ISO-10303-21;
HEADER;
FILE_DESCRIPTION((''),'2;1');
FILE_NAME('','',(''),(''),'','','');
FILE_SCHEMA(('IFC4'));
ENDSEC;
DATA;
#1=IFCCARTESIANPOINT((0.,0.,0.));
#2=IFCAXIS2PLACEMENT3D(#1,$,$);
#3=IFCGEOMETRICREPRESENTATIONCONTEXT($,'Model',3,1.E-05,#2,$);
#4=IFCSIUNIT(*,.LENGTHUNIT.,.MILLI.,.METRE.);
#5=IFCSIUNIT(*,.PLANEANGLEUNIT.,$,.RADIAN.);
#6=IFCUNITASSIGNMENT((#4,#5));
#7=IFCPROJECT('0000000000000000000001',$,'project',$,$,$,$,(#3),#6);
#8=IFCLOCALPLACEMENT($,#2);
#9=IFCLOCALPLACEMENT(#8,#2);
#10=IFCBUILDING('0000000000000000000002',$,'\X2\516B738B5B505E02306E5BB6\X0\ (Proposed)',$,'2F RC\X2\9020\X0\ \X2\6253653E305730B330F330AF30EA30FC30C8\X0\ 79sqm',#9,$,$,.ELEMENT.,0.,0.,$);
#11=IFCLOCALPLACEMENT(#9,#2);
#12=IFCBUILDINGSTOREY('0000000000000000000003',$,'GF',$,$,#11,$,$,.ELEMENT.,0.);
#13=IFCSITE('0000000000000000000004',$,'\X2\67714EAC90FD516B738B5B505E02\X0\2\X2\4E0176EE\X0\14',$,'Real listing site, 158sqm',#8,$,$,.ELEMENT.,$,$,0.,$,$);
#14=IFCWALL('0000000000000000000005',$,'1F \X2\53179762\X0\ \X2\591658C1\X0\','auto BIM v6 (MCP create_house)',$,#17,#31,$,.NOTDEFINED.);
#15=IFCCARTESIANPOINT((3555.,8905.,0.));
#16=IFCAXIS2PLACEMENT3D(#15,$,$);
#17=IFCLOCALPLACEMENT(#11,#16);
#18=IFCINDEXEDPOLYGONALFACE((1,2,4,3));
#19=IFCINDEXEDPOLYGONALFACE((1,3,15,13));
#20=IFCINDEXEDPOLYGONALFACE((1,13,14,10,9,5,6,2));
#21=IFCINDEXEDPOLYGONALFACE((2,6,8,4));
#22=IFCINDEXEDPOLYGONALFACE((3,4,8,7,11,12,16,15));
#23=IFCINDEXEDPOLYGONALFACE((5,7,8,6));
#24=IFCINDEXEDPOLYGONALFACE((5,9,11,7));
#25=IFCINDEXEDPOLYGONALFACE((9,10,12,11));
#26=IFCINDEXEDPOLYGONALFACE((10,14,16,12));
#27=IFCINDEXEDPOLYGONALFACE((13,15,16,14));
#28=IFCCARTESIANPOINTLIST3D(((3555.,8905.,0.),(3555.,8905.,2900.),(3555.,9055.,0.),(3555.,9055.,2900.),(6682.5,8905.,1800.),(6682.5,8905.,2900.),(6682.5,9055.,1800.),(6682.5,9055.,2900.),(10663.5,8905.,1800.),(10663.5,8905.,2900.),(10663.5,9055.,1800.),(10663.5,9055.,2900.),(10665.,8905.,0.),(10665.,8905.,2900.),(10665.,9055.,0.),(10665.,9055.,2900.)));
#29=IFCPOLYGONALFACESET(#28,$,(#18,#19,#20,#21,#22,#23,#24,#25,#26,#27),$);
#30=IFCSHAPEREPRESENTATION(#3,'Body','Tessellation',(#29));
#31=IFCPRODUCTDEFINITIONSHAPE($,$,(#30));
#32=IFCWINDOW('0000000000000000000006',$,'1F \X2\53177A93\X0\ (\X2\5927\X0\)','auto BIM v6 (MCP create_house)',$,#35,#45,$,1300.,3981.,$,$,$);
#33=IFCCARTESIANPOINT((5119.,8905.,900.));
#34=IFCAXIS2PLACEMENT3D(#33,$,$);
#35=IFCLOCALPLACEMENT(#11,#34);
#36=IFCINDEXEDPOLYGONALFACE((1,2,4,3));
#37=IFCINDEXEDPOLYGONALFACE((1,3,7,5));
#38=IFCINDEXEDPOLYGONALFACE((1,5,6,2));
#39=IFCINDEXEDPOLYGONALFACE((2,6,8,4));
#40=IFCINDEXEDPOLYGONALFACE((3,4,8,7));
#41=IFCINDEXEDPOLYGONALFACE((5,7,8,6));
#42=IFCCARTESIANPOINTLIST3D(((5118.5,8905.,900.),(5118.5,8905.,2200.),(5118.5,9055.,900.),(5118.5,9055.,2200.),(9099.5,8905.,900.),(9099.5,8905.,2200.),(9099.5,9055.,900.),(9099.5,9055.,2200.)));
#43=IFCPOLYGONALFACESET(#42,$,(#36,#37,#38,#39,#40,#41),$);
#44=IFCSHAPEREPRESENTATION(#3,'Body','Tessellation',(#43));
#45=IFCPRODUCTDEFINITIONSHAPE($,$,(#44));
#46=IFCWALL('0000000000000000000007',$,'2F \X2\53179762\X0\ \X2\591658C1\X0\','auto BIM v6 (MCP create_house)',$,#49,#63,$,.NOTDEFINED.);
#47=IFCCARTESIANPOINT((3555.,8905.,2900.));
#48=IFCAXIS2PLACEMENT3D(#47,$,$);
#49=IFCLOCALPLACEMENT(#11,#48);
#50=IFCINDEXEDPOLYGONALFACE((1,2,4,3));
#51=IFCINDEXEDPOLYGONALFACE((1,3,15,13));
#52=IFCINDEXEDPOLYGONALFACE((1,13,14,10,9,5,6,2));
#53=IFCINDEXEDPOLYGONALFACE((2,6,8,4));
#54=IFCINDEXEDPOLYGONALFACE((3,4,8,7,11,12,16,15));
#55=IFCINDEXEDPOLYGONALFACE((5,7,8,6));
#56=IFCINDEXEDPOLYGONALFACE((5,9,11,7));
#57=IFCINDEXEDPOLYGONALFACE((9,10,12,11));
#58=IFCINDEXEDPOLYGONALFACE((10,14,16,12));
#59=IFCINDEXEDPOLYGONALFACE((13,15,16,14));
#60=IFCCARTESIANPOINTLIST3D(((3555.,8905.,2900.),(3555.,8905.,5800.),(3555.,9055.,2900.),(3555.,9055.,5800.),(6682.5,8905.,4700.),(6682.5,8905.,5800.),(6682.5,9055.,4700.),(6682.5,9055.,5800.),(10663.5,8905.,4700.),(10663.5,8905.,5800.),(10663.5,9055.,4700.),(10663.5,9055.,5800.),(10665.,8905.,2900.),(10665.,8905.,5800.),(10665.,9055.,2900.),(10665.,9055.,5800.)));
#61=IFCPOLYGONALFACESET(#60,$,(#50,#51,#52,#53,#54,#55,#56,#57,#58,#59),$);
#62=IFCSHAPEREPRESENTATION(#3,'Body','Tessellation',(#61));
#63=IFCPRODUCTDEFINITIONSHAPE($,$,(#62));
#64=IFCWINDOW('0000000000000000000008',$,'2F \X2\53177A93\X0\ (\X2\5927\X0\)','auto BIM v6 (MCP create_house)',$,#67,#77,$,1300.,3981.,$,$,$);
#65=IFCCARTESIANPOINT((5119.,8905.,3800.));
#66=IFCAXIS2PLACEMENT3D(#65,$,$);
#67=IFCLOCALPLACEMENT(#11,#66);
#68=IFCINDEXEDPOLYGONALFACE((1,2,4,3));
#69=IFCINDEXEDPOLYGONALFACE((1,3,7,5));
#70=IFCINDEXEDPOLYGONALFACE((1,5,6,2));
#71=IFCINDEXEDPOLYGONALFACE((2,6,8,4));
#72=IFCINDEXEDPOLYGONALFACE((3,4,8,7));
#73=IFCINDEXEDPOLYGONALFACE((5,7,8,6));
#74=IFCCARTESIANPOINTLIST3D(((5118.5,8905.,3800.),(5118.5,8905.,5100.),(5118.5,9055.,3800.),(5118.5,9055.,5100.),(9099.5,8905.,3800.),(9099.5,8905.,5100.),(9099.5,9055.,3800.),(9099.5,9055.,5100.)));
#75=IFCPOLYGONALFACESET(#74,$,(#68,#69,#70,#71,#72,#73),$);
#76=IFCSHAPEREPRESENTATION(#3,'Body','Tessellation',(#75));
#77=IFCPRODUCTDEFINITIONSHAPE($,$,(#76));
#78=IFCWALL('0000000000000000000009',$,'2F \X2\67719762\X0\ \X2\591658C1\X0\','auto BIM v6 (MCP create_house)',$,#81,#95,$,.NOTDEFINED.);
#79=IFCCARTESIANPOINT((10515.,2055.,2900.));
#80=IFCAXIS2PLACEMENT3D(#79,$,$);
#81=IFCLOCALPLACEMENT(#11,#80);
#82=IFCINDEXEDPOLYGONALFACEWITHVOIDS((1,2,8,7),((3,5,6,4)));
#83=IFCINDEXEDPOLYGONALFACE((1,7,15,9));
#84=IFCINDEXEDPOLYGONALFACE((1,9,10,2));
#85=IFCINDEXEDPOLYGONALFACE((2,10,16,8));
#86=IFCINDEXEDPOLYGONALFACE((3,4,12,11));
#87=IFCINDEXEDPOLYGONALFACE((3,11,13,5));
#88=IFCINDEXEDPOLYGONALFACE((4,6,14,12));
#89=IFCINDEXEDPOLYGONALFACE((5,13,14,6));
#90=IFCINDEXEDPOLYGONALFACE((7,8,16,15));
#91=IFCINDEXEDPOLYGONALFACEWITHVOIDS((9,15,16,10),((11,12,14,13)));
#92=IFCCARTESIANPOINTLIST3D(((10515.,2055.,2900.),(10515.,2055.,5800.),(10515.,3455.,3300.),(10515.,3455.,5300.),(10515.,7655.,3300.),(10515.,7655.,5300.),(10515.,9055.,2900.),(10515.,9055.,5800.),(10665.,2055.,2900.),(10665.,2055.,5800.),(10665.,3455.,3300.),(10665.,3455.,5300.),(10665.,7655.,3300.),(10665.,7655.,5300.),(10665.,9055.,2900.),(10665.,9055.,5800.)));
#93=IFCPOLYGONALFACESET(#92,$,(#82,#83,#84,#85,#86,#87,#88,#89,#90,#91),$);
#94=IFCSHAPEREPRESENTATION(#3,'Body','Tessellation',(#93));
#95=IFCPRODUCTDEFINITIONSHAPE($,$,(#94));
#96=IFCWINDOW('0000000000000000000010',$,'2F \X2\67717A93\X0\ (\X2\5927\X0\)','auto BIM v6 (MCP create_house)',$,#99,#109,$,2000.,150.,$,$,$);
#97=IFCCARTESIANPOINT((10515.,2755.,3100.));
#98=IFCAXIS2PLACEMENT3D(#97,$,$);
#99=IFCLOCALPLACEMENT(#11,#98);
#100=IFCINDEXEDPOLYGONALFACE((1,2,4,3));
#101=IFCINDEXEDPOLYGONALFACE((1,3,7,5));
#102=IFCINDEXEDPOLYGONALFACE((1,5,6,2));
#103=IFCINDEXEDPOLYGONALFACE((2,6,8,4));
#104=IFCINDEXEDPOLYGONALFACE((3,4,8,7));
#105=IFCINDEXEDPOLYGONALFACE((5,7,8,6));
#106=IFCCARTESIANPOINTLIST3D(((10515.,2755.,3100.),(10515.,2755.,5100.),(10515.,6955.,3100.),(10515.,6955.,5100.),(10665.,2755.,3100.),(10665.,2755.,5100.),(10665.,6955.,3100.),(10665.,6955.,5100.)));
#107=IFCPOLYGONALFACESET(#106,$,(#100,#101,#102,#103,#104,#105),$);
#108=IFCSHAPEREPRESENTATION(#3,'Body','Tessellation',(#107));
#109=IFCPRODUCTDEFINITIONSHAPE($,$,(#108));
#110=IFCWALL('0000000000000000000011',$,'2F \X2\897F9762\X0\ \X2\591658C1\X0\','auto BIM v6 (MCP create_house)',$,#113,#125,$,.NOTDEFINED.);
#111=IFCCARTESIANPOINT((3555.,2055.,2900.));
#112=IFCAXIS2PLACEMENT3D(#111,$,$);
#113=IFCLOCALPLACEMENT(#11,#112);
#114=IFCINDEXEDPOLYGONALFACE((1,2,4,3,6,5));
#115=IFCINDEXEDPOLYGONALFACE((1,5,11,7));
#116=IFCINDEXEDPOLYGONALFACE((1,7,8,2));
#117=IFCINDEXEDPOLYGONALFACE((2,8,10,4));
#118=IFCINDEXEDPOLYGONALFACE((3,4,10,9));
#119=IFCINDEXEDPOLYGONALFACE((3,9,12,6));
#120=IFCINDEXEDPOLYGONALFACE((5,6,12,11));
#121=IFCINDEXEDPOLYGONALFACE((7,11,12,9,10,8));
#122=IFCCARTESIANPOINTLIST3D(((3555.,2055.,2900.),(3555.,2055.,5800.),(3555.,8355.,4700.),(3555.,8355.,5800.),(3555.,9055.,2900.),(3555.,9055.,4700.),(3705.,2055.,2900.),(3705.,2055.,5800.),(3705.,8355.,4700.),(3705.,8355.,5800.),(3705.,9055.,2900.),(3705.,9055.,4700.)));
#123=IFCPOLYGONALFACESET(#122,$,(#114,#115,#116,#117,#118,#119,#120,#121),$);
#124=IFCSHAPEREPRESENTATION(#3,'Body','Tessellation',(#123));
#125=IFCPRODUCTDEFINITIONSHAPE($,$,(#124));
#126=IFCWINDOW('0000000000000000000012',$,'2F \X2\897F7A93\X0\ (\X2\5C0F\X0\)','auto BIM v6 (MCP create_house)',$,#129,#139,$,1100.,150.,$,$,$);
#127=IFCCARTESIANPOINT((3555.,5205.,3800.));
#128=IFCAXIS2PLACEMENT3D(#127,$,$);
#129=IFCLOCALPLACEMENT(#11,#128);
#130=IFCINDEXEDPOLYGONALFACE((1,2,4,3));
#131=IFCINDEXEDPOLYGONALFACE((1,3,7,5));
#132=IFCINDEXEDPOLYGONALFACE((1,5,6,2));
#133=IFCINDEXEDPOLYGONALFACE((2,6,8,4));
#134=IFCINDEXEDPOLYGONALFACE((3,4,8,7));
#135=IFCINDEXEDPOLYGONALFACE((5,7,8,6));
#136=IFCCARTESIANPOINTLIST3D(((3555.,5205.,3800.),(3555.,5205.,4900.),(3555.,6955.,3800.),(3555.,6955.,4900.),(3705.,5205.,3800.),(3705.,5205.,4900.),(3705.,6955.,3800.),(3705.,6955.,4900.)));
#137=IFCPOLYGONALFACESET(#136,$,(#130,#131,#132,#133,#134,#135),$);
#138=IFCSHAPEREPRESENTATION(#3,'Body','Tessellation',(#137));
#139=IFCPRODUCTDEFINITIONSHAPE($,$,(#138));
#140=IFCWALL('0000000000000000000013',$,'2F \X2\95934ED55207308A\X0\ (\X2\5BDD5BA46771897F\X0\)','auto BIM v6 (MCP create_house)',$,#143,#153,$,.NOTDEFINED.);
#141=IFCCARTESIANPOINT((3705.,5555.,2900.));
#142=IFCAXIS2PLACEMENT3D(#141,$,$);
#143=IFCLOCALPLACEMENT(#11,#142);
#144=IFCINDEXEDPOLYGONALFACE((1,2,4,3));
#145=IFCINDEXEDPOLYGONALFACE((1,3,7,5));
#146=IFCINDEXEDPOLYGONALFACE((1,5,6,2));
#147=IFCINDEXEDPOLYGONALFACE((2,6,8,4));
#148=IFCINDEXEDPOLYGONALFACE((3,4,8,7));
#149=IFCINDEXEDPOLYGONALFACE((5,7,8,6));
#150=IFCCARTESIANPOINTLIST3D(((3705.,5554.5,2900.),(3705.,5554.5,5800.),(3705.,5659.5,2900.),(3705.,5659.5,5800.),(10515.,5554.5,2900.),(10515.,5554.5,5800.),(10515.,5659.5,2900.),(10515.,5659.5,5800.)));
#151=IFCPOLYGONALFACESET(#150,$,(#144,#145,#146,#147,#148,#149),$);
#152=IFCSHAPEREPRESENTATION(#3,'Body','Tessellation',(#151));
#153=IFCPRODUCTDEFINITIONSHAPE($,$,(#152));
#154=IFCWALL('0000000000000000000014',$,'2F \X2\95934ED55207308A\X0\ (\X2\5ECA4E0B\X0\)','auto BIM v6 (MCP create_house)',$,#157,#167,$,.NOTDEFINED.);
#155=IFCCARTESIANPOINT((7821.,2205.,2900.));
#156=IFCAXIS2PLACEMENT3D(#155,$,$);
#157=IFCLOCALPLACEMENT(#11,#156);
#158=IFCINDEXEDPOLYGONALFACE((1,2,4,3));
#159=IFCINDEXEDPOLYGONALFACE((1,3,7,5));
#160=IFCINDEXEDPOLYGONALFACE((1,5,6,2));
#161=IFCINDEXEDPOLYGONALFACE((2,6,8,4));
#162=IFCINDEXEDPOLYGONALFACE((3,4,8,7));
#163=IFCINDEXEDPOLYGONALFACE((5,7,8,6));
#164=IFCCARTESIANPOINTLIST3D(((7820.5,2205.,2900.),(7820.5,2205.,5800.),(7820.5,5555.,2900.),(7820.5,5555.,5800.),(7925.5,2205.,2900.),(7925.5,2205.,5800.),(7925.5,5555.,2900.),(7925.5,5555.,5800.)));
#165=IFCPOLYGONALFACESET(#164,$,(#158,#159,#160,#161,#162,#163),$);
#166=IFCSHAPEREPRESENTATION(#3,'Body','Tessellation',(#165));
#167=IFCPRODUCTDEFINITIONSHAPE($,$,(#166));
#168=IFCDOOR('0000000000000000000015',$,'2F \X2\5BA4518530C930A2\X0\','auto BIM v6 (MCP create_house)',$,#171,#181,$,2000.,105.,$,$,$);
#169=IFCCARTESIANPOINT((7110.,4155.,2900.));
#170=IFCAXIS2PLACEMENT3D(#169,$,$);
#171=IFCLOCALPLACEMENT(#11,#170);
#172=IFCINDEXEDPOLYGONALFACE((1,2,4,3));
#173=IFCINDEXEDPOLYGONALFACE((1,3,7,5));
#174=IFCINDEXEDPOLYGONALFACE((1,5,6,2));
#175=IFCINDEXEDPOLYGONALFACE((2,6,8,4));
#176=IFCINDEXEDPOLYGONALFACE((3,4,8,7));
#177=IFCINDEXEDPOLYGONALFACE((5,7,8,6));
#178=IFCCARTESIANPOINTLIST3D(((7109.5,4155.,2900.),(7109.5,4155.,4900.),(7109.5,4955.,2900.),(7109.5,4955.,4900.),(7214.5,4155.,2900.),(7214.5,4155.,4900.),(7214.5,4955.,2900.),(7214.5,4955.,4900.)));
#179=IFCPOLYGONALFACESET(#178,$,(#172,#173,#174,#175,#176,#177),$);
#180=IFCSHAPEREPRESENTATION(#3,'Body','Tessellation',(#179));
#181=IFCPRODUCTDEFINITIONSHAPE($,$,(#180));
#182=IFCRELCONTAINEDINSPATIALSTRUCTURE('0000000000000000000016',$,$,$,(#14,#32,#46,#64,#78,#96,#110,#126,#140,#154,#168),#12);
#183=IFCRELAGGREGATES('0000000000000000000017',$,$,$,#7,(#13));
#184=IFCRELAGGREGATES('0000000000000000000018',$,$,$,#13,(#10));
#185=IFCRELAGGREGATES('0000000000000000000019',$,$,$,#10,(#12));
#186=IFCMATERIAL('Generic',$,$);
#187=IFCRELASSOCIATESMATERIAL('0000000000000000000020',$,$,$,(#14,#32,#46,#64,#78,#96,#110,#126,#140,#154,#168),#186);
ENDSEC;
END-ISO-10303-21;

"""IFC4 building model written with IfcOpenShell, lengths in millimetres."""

from ifc_helpers import new_model, si_unit, frame, frame_2d, origin, place, context, project, spatial, rectangle, extrude, material, element, fill, save


model = new_model("IFC4")

# Units and contexts
model_context = context("Model", 3, precision=1e-05, world=origin())
ifc_project = project(units=[si_unit("LENGTHUNIT", "METRE", prefix="MILLI"), si_unit("PLANEANGLEUNIT", "RADIAN")], contexts=[model_context])

# Site, building, storey
site_placement = place(None, origin())
site = spatial("IfcSite", under=ifc_project, at=site_placement, Name="東京都八王子市2丁目14", ObjectType="Real listing site, 158sqm", CompositionType="ELEMENT", RefElevation=0.0)
building_placement = place(site_placement, origin())
building = spatial("IfcBuilding", under=site, at=building_placement, Name="八王子市の家 (Proposed)", ObjectType="2F RC造 打放しコンクリート 79sqm", CompositionType="ELEMENT", ElevationOfRefHeight=0.0, ElevationOfTerrain=0.0)
storey_placement = place(building_placement, origin())
storey = spatial("IfcBuildingStorey", under=building, at=storey_placement, Name="GF", CompositionType="ELEMENT", Elevation=0.0)

# Wall, opening, window
ifc_material = material(Name="Generic")
wall_1_placement = place(storey_placement, frame((3555.0, 8905.0, 0.0)))
wall_1 = element("IfcWall", 1, at=wall_1_placement, inside=storey, material=ifc_material, Name="1F 北面 外壁", Description="auto BIM v6 (MCP create_house)", PredefinedType="NOTDEFINED", context=model_context, shape_type="SweptSolid", body=[
    extrude(rectangle(XDim=7110.0, YDim=150.0, at=frame_2d((3555.0, 75.0))), frame((3555.0, 8905.0, 0.0)), (0.0, 0.0, 1.0), 2900.0),
])
opening_1_placement = place(storey_placement, frame((5119.0, 8905.0, 900.0)))
opening_1 = element("IfcOpeningElement", 2, at=opening_1_placement, cuts=wall_1, PredefinedType="NOTDEFINED", context=model_context, shape_type="SweptSolid", body=[
    extrude(rectangle(XDim=3981.0, YDim=150.0, at=frame_2d((1990.0, 75.0))), frame((5119.0, 8905.0, 900.0)), (0.0, 0.0, 1.0), 1300.0),
])
window_1_placement = place(storey_placement, frame((5119.0, 8905.0, 900.0)))
window_1 = element("IfcWindow", 3, at=window_1_placement, inside=storey, material=ifc_material, Name="1F 北窓 (大)", Description="auto BIM v6 (MCP create_house)", OverallHeight=1300.0, OverallWidth=3981.0, context=model_context, shape_type="SweptSolid", body=[
    extrude(rectangle(XDim=3981.0, YDim=150.0, at=frame_2d((1990.0, 75.0))), frame((5119.0, 8905.0, 900.0)), (0.0, 0.0, 1.0), 1300.0),
])
fill(opening_1, window_1)

# Walls, openings, windows
wall_2_placement = place(storey_placement, frame((3555.0, 8905.0, 2900.0)))
wall_2 = element("IfcWall", 4, at=wall_2_placement, inside=storey, material=ifc_material, Name="2F 北面 外壁", Description="auto BIM v6 (MCP create_house)", PredefinedType="NOTDEFINED", context=model_context, shape_type="SweptSolid", body=[
    extrude(rectangle(XDim=7110.0, YDim=150.0, at=frame_2d((3555.0, 75.0))), frame((3555.0, 8905.0, 2900.0)), (0.0, 0.0, 1.0), 2900.0),
])
opening_2_placement = place(storey_placement, frame((5119.0, 8905.0, 3800.0)))
opening_2 = element("IfcOpeningElement", 5, at=opening_2_placement, cuts=wall_2, PredefinedType="NOTDEFINED", context=model_context, shape_type="SweptSolid", body=[
    extrude(rectangle(XDim=3981.0, YDim=150.0, at=frame_2d((1990.0, 75.0))), frame((5119.0, 8905.0, 3800.0)), (0.0, 0.0, 1.0), 1300.0),
])
window_2_placement = place(storey_placement, frame((5119.0, 8905.0, 3800.0)))
window_2 = element("IfcWindow", 6, at=window_2_placement, inside=storey, material=ifc_material, Name="2F 北窓 (大)", Description="auto BIM v6 (MCP create_house)", OverallHeight=1300.0, OverallWidth=3981.0, context=model_context, shape_type="SweptSolid", body=[
    extrude(rectangle(XDim=3981.0, YDim=150.0, at=frame_2d((1990.0, 75.0))), frame((5119.0, 8905.0, 3800.0)), (0.0, 0.0, 1.0), 1300.0),
])
fill(opening_2, window_2)
wall_3_placement = place(storey_placement, frame((10515.0, 2055.0, 2900.0)))
wall_3 = element("IfcWall", 7, at=wall_3_placement, inside=storey, material=ifc_material, Name="2F 東面 外壁", Description="auto BIM v6 (MCP create_house)", PredefinedType="NOTDEFINED", context=model_context, shape_type="SweptSolid", body=[
    extrude(rectangle(XDim=150.0, YDim=7000.0, at=frame_2d((75.0, 3500.0))), frame((10515.0, 2055.0, 2900.0)), (0.0, 0.0, 1.0), 2900.0),
])
opening_3_placement = place(storey_placement, frame((10515.0, 2755.0, 3100.0)))
opening_3 = element("IfcOpeningElement", 8, at=opening_3_placement, cuts=wall_3, PredefinedType="NOTDEFINED", context=model_context, shape_type="SweptSolid", body=[
    extrude(rectangle(XDim=150.0, YDim=4200.0, at=frame_2d((75.0, 2100.0))), frame((10515.0, 2755.0, 3100.0)), (0.0, 0.0, 1.0), 2000.0),
])
window_3_placement = place(storey_placement, frame((10515.0, 2755.0, 3100.0)))
window_3 = element("IfcWindow", 9, at=window_3_placement, inside=storey, material=ifc_material, Name="2F 東窓 (大)", Description="auto BIM v6 (MCP create_house)", OverallHeight=2000.0, OverallWidth=150.0, context=model_context, shape_type="SweptSolid", body=[
    extrude(rectangle(XDim=150.0, YDim=4200.0, at=frame_2d((75.0, 2100.0))), frame((10515.0, 2755.0, 3100.0)), (0.0, 0.0, 1.0), 2000.0),
])
fill(opening_3, window_3)
wall_4_placement = place(storey_placement, frame((3555.0, 2055.0, 2900.0)))
wall_4 = element("IfcWall", 10, at=wall_4_placement, inside=storey, material=ifc_material, Name="2F 西面 外壁", Description="auto BIM v6 (MCP create_house)", PredefinedType="NOTDEFINED", context=model_context, shape_type="SweptSolid", body=[
    extrude(rectangle(XDim=150.0, YDim=7000.0, at=frame_2d((75.0, 3500.0))), frame((3555.0, 2055.0, 2900.0)), (0.0, 0.0, 1.0), 2900.0),
])
opening_4_placement = place(storey_placement, frame((3555.0, 5205.0, 3800.0)))
opening_4 = element("IfcOpeningElement", 11, at=opening_4_placement, cuts=wall_4, PredefinedType="NOTDEFINED", context=model_context, shape_type="SweptSolid", body=[
    extrude(rectangle(XDim=150.0, YDim=1750.0, at=frame_2d((75.0, 875.0))), frame((3555.0, 5205.0, 3800.0)), (0.0, 0.0, 1.0), 1100.0),
])
window_4_placement = place(storey_placement, frame((3555.0, 5205.0, 3800.0)))
window_4 = element("IfcWindow", 12, at=window_4_placement, inside=storey, material=ifc_material, Name="2F 西窓 (小)", Description="auto BIM v6 (MCP create_house)", OverallHeight=1100.0, OverallWidth=150.0, context=model_context, shape_type="SweptSolid", body=[
    extrude(rectangle(XDim=150.0, YDim=1750.0, at=frame_2d((75.0, 875.0))), frame((3555.0, 5205.0, 3800.0)), (0.0, 0.0, 1.0), 1100.0),
])
fill(opening_4, window_4)

# Walls
wall_5_placement = place(storey_placement, frame((3705.0, 5555.0, 2900.0)))
element("IfcWall", 13, at=wall_5_placement, inside=storey, material=ifc_material, Name="2F 間仕切り (寝室東西)", Description="auto BIM v6 (MCP create_house)", PredefinedType="NOTDEFINED", context=model_context, shape_type="SweptSolid", body=[
    extrude(rectangle(XDim=6810.0, YDim=105.0, at=frame_2d((3405.0, 52.0))), frame((3705.0, 5555.0, 2900.0)), (0.0, 0.0, 1.0), 2900.0),
])
wall_6_placement = place(storey_placement, frame((7821.0, 2205.0, 2900.0)))
element("IfcWall", 14, at=wall_6_placement, inside=storey, material=ifc_material, Name="2F 間仕切り (廊下)", Description="auto BIM v6 (MCP create_house)", PredefinedType="NOTDEFINED", context=model_context, shape_type="SweptSolid", body=[
    extrude(rectangle(XDim=105.0, YDim=3350.0, at=frame_2d((52.0, 1675.0))), frame((7821.0, 2205.0, 2900.0)), (0.0, 0.0, 1.0), 2900.0),
])

# Door
door_placement = place(storey_placement, frame((7110.0, 4155.0, 2900.0)))
element("IfcDoor", 15, at=door_placement, inside=storey, material=ifc_material, Name="2F 室内ドア", Description="auto BIM v6 (MCP create_house)", OverallHeight=2000.0, OverallWidth=105.0, context=model_context, shape_type="SweptSolid", body=[
    extrude(rectangle(XDim=105.0, YDim=800.0, at=frame_2d((52.0, 400.0))), frame((7110.0, 4155.0, 2900.0)), (0.0, 0.0, 1.0), 2000.0),
])

save(model, "model.ifc")
